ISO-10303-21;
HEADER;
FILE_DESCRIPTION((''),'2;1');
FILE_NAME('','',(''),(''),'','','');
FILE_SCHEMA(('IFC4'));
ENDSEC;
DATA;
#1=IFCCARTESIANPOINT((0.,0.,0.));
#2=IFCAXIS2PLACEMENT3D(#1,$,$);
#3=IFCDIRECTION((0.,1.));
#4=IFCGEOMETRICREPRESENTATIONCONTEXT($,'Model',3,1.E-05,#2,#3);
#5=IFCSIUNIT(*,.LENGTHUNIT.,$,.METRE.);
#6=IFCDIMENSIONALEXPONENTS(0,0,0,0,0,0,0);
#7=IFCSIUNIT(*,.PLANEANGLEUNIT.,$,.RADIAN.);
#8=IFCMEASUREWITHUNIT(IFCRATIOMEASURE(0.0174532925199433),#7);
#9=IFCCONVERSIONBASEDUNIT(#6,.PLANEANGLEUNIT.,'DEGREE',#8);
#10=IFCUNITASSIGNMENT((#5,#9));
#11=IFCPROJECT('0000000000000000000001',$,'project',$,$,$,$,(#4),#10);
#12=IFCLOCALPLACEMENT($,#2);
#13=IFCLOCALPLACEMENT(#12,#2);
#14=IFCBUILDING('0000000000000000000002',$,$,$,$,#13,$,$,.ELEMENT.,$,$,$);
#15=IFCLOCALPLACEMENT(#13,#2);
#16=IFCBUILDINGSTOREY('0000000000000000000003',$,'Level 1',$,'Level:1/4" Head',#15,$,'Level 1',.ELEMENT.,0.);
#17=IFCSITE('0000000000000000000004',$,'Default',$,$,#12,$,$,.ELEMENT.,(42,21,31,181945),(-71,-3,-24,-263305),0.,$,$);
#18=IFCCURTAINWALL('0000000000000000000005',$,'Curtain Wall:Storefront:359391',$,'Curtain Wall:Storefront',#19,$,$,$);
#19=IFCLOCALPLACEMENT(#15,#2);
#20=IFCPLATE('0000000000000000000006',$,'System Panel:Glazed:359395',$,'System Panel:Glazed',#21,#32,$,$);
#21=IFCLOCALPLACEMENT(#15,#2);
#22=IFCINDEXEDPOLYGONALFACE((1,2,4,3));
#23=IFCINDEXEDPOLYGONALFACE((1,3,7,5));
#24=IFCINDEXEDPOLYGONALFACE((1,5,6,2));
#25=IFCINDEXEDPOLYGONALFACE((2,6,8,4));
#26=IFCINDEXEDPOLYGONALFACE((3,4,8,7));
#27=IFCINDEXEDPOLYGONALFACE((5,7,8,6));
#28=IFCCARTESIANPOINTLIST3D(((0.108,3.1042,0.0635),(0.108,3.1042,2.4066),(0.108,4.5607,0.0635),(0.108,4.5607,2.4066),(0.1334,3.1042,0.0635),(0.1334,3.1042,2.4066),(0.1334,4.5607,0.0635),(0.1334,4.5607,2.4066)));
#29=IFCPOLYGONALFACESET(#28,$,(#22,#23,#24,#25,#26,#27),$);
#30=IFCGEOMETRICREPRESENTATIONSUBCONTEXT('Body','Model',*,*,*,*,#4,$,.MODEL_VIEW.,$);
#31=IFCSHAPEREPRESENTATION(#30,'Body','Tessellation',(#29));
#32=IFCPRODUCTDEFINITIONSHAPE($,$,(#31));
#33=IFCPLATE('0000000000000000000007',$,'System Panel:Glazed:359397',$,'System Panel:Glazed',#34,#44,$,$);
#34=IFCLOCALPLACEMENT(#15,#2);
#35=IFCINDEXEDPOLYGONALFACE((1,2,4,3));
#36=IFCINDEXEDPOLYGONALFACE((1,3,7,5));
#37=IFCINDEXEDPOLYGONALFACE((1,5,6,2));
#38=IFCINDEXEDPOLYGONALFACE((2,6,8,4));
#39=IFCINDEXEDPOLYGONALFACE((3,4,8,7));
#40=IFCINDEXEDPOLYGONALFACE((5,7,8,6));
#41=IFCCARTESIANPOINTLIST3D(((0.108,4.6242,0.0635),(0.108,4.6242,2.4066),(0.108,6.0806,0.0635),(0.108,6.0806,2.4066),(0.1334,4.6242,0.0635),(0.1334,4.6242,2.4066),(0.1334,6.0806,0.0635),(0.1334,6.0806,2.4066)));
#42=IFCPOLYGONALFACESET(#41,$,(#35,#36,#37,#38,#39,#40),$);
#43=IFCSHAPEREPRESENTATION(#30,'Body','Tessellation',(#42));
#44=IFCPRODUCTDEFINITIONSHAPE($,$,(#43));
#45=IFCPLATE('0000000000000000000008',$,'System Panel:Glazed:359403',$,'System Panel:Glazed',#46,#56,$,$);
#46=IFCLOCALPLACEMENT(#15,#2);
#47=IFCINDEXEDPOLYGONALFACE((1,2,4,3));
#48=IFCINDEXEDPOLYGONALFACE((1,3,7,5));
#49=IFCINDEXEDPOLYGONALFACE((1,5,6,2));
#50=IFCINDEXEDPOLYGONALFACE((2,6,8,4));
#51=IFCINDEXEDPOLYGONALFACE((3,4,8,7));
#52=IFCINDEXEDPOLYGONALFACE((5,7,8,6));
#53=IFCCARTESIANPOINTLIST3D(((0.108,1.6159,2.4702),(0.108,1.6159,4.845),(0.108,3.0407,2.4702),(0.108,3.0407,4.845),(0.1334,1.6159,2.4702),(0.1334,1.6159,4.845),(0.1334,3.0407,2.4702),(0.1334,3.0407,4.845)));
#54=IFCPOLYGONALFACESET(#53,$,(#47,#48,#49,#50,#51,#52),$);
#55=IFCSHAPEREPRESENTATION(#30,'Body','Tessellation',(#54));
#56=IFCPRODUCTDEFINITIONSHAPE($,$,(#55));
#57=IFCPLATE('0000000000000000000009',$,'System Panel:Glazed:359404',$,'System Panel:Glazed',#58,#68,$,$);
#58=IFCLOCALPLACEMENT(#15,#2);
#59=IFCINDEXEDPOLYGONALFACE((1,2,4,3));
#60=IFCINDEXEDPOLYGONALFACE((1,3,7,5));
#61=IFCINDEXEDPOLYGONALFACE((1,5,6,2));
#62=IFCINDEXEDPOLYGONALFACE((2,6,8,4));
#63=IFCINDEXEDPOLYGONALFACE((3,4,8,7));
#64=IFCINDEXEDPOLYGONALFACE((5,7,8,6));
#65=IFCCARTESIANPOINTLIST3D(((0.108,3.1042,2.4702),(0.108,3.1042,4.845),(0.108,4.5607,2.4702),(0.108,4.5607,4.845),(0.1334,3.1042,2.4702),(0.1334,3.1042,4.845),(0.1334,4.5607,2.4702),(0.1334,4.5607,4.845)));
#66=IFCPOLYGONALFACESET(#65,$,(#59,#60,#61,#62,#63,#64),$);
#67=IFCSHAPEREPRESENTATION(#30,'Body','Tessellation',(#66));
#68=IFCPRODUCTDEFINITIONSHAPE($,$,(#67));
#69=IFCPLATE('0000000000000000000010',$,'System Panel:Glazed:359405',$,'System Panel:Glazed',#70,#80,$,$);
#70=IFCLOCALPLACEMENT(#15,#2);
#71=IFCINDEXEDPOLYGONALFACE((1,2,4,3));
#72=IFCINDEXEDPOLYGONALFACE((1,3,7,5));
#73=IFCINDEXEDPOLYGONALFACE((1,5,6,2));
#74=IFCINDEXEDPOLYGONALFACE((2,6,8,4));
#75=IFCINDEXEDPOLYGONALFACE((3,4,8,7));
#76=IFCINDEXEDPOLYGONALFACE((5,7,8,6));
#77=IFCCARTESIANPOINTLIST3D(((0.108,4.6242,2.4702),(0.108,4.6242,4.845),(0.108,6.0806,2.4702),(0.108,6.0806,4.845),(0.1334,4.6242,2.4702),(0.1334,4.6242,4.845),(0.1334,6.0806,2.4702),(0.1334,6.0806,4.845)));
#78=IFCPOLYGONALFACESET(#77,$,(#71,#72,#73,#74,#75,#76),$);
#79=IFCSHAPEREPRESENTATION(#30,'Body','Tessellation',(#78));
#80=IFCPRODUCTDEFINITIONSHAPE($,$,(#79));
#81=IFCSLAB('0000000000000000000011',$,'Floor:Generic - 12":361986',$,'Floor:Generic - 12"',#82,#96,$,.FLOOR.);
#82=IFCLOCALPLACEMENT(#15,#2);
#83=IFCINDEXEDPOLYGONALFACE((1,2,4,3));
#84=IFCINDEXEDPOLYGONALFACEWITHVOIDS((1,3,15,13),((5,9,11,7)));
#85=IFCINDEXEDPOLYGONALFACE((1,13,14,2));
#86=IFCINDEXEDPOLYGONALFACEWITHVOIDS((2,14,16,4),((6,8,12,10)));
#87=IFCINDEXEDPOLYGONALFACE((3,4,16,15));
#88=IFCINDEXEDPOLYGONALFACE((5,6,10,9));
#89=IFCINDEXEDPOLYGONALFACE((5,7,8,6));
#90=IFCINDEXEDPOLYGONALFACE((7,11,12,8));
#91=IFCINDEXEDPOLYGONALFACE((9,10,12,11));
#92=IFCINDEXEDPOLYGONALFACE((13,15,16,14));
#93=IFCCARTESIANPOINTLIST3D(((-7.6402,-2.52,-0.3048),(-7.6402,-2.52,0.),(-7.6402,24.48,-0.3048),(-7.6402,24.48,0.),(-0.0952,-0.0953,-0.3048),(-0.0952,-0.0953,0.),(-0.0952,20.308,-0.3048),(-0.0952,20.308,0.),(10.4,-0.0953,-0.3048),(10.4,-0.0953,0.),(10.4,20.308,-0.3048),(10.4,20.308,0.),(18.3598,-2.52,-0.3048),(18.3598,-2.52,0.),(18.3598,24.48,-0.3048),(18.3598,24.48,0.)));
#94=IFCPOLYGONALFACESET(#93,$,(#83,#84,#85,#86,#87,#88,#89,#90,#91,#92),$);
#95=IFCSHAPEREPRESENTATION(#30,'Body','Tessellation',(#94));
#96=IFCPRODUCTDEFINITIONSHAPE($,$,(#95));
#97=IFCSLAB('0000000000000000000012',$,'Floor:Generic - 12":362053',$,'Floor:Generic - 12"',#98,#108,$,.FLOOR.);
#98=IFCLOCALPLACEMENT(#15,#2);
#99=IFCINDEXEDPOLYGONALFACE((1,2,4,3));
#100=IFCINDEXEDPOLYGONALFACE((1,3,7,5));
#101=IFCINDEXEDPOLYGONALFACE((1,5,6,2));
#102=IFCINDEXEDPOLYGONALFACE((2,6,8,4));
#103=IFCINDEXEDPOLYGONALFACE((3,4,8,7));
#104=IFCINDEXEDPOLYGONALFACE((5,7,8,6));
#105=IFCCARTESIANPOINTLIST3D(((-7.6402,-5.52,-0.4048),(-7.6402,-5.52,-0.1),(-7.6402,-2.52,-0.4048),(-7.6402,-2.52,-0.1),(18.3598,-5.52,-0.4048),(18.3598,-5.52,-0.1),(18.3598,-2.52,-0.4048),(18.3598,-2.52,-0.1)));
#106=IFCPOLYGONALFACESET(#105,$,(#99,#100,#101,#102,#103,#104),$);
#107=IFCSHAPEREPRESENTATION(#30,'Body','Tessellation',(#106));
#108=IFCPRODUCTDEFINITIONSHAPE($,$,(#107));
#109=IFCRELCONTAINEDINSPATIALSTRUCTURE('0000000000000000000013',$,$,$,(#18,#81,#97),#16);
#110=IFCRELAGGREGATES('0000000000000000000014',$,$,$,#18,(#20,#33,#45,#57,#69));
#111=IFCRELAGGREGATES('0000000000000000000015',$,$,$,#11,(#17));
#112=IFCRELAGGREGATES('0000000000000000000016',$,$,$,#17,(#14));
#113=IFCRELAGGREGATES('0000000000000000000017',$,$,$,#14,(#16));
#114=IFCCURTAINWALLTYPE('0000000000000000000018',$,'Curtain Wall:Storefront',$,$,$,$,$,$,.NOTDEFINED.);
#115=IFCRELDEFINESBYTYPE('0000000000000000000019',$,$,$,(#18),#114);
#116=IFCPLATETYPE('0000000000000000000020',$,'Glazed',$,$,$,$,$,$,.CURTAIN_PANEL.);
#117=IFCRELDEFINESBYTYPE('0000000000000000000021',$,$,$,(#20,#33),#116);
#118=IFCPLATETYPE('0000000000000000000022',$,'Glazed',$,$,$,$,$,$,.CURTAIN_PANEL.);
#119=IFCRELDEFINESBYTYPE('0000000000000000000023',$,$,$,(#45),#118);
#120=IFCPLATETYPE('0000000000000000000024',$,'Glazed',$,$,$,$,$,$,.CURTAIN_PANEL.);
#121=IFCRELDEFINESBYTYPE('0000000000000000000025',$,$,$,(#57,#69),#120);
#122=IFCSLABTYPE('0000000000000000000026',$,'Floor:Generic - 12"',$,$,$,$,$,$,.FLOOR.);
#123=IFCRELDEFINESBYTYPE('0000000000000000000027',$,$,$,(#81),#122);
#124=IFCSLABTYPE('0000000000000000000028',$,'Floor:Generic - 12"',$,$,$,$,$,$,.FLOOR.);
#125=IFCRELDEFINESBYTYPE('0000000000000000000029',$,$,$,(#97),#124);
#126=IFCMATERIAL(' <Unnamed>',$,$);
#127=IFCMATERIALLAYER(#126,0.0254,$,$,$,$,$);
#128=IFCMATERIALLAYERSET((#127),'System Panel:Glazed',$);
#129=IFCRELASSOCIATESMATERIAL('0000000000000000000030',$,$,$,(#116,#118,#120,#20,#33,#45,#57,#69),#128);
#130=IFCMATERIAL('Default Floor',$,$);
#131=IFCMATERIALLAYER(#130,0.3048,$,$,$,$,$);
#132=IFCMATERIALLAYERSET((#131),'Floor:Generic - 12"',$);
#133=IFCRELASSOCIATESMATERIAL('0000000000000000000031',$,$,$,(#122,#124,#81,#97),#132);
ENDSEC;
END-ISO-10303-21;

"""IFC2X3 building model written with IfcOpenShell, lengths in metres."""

from ifc_helpers import new_model, entity, si_unit, converted_unit, direction, frame, frame_2d, origin, origin_2d_with_axis, place, context, subcontext, project, spatial, rectangle, extrude, source, transform, mapped, material, layer, layer_set, layer_usage, type_object, type_shapes, element, aggregate, save


model = new_model("IFC2X3")

# Units and contexts
model_context = context("Model", 3, precision=1e-05, world=origin(), true_north=direction((0.0, 1.0)))
body_context = subcontext(model_context, "Body", "Model", "MODEL_VIEW")
ifc_project = project(units=[si_unit("LENGTHUNIT", "METRE"), converted_unit("PLANEANGLEUNIT", "DEGREE", entity("IfcRatioMeasure", 0.0174532925199433), si_unit("PLANEANGLEUNIT", "RADIAN"), dimensions=[0, 0, 0, 0, 0, 0, 0])], contexts=[model_context])

# Site, building, storey
site_placement = place(None, origin())
site = spatial("IfcSite", under=ifc_project, at=site_placement, Name="Default", CompositionType="ELEMENT", RefLatitude=(42, 21, 31, 181945), RefLongitude=(-71, -3, -24, -263305), RefElevation=0.0)
building_placement = place(site_placement, origin())
building = spatial("IfcBuilding", under=site, at=building_placement, CompositionType="ELEMENT")
storey_placement = place(building_placement, origin())
storey = spatial("IfcBuildingStorey", under=building, at=storey_placement, Name="Level 1", ObjectType="Level:1/4\" Head", LongName="Level 1", CompositionType="ELEMENT", Elevation=0.0)

# Curtain wall
curtain_wall_type = type_object("IfcCurtainWallType", Name="Curtain Wall:Storefront", PredefinedType="NOTDEFINED")
curtain_wall_placement = place(storey_placement, origin())
curtain_wall = element("IfcCurtainWall", 1, at=curtain_wall_placement, inside=storey, type_object=curtain_wall_type, Name="Curtain Wall:Storefront:359391", ObjectType="Curtain Wall:Storefront")

# Plates
ifc_material_1 = material(Name=" <Unnamed>")
ifc_layer_1 = layer(ifc_material_1, 0.0254)
ifc_layer_set_1 = layer_set([ifc_layer_1], Name="System Panel:Glazed")
ifc_layer_usage_1 = layer_usage(ifc_layer_set_1, "AXIS3", "POSITIVE", 0.1042)
plate_type_1 = type_object("IfcPlateType", Name="Glazed", PredefinedType="CURTAIN_PANEL", material=ifc_layer_set_1)
shared_shape_1 = source(origin(), body_context, "Body", "SweptSolid", [
    extrude(rectangle(XDim=0.0254, YDim=1.4565, at=frame_2d((0.0, 0.0), x_axis=(1.0, 0.0))), frame((0.7282, 0.0127, 0.0), z_axis=(0.0, 0.0, 1.0), x_axis=(0.0, 1.0, 0.0)), (0.0, 0.0, 1.0), 2.3432),
])
type_shapes(plate_type_1, [shared_shape_1])
plate_1_placement = place(curtain_wall_placement, frame((0.1334, 3.1042, 0.0635), z_axis=(0.0, 0.0, 1.0), x_axis=(0.0, 1.0, 0.0)))
plate_1 = element("IfcPlate", 2, at=plate_1_placement, type_object=plate_type_1, material=ifc_layer_usage_1, Name="System Panel:Glazed:359395", ObjectType="System Panel:Glazed", context=body_context, shape_type="MappedRepresentation", body=[
    mapped(shared_shape_1, transform((0.0, 0.0, 0.0), scale=1.0)),
])
ifc_layer_usage_2 = layer_usage(ifc_layer_set_1, "AXIS3", "POSITIVE", 0.1042)
plate_2_placement = place(curtain_wall_placement, frame((0.1334, 4.6242, 0.0635), z_axis=(0.0, 0.0, 1.0), x_axis=(0.0, 1.0, 0.0)))
plate_2 = element("IfcPlate", 3, at=plate_2_placement, type_object=plate_type_1, material=ifc_layer_usage_2, Name="System Panel:Glazed:359397", ObjectType="System Panel:Glazed", context=body_context, shape_type="MappedRepresentation", body=[
    mapped(shared_shape_1, transform((0.0, 0.0, 0.0), scale=1.0)),
])
ifc_layer_usage_3 = layer_usage(ifc_layer_set_1, "AXIS3", "POSITIVE", 0.1042)
plate_type_2 = type_object("IfcPlateType", Name="Glazed", PredefinedType="CURTAIN_PANEL", material=ifc_layer_set_1)
shared_shape_2 = source(origin(), body_context, "Body", "SweptSolid", [
    extrude(rectangle(XDim=0.0254, YDim=1.4248, at=frame_2d((0.0, 0.0), x_axis=(1.0, 0.0))), frame((0.7124, 0.0127, 0.0), z_axis=(0.0, 0.0, 1.0), x_axis=(0.0, 1.0, 0.0)), (0.0, 0.0, 1.0), 2.3749),
])
type_shapes(plate_type_2, [shared_shape_2])
plate_3_placement = place(curtain_wall_placement, frame((0.1334, 1.6159, 2.4701), z_axis=(0.0, 0.0, 1.0), x_axis=(0.0, 1.0, 0.0)))
plate_3 = element("IfcPlate", 4, at=plate_3_placement, type_object=plate_type_2, material=ifc_layer_usage_3, Name="System Panel:Glazed:359403", ObjectType="System Panel:Glazed", context=body_context, shape_type="MappedRepresentation", body=[
    mapped(shared_shape_2, transform((0.0, 0.0, 0.0), scale=1.0)),
])
ifc_layer_usage_4 = layer_usage(ifc_layer_set_1, "AXIS3", "POSITIVE", 0.1042)
plate_type_3 = type_object("IfcPlateType", Name="Glazed", PredefinedType="CURTAIN_PANEL", material=ifc_layer_set_1)
shared_shape_3 = source(origin(), body_context, "Body", "SweptSolid", [
    extrude(rectangle(XDim=0.0254, YDim=1.4565, at=frame_2d((0.0, 0.0), x_axis=(1.0, 0.0))), frame((0.7282, 0.0127, 0.0), z_axis=(0.0, 0.0, 1.0), x_axis=(0.0, 1.0, 0.0)), (0.0, 0.0, 1.0), 2.3749),
])
type_shapes(plate_type_3, [shared_shape_3])
plate_4_placement = place(curtain_wall_placement, frame((0.1334, 3.1042, 2.4701), z_axis=(0.0, 0.0, 1.0), x_axis=(0.0, 1.0, 0.0)))
plate_4 = element("IfcPlate", 5, at=plate_4_placement, type_object=plate_type_3, material=ifc_layer_usage_4, Name="System Panel:Glazed:359404", ObjectType="System Panel:Glazed", context=body_context, shape_type="MappedRepresentation", body=[
    mapped(shared_shape_3, transform((0.0, 0.0, 0.0), scale=1.0)),
])
ifc_layer_usage_5 = layer_usage(ifc_layer_set_1, "AXIS3", "POSITIVE", 0.1042)
plate_5_placement = place(curtain_wall_placement, frame((0.1334, 4.6242, 2.4701), z_axis=(0.0, 0.0, 1.0), x_axis=(0.0, 1.0, 0.0)))
plate_5 = element("IfcPlate", 6, at=plate_5_placement, type_object=plate_type_3, material=ifc_layer_usage_5, Name="System Panel:Glazed:359405", ObjectType="System Panel:Glazed", context=body_context, shape_type="MappedRepresentation", body=[
    mapped(shared_shape_3, transform((0.0, 0.0, 0.0), scale=1.0)),
])
aggregate(curtain_wall, [plate_1, plate_2, plate_3, plate_4, plate_5])

# Slab, opening
ifc_material_2 = material(Name="Default Floor")
ifc_layer_2 = layer(ifc_material_2, 0.3048)
ifc_layer_set_2 = layer_set([ifc_layer_2], Name="Floor:Generic - 12\"")
ifc_layer_usage_6 = layer_usage(ifc_layer_set_2, "AXIS3", "POSITIVE", 0.0)
slab_type_1 = type_object("IfcSlabType", Name="Floor:Generic - 12\"", PredefinedType="FLOOR", material=ifc_layer_set_2)
slab_1_placement = place(storey_placement, origin())
slab_1 = element("IfcSlab", 7, at=slab_1_placement, inside=storey, type_object=slab_type_1, material=ifc_layer_usage_6, Name="Floor:Generic - 12\":361986", ObjectType="Floor:Generic - 12\"", PredefinedType="FLOOR", context=body_context, shape_type="SweptSolid", body=[
    extrude(rectangle(XDim=27.0, YDim=26.0, at=frame_2d((0.0, 0.0), x_axis=(0.0, -1.0))), frame((5.3598, 10.98, 0.0), z_axis=(0.0, 0.0, -1.0), x_axis=(-1.0, 0.0, 0.0)), (0.0, 0.0, 1.0), 0.3048),
])
opening_1_placement = place(slab_1_placement, frame((5.1524, 10.1064, 0.0)))
element("IfcOpeningElement", 8, at=opening_1_placement, cuts=slab_1, ObjectType="Opening", context=body_context, shape_type="SweptSolid", body=[
    extrude(rectangle(XDim=20.4032, YDim=10.4953, at=origin_2d_with_axis()), frame((0.0, 0.0, 0.0), z_axis=(0.0, 0.0, -1.0), x_axis=(0.0, -1.0, 0.0)), (0.0, 0.0, 1.0), 0.3048),
])

# Slab
ifc_layer_usage_7 = layer_usage(ifc_layer_set_2, "AXIS3", "POSITIVE", 0.0)
slab_type_2 = type_object("IfcSlabType", Name="Floor:Generic - 12\"", PredefinedType="FLOOR", material=ifc_layer_set_2)
slab_2_placement = place(storey_placement, origin())
element("IfcSlab", 9, at=slab_2_placement, inside=storey, type_object=slab_type_2, material=ifc_layer_usage_7, Name="Floor:Generic - 12\":362053", ObjectType="Floor:Generic - 12\"", PredefinedType="FLOOR", context=body_context, shape_type="SweptSolid", body=[
    extrude(rectangle(XDim=3.0, YDim=26.0, at=origin_2d_with_axis()), frame((5.3598, -4.02, -0.1), z_axis=(0.0, 0.0, -1.0), x_axis=(0.0, 1.0, 0.0)), (0.0, 0.0, 1.0), 0.3048),
])

save(model, "model.ifc")
